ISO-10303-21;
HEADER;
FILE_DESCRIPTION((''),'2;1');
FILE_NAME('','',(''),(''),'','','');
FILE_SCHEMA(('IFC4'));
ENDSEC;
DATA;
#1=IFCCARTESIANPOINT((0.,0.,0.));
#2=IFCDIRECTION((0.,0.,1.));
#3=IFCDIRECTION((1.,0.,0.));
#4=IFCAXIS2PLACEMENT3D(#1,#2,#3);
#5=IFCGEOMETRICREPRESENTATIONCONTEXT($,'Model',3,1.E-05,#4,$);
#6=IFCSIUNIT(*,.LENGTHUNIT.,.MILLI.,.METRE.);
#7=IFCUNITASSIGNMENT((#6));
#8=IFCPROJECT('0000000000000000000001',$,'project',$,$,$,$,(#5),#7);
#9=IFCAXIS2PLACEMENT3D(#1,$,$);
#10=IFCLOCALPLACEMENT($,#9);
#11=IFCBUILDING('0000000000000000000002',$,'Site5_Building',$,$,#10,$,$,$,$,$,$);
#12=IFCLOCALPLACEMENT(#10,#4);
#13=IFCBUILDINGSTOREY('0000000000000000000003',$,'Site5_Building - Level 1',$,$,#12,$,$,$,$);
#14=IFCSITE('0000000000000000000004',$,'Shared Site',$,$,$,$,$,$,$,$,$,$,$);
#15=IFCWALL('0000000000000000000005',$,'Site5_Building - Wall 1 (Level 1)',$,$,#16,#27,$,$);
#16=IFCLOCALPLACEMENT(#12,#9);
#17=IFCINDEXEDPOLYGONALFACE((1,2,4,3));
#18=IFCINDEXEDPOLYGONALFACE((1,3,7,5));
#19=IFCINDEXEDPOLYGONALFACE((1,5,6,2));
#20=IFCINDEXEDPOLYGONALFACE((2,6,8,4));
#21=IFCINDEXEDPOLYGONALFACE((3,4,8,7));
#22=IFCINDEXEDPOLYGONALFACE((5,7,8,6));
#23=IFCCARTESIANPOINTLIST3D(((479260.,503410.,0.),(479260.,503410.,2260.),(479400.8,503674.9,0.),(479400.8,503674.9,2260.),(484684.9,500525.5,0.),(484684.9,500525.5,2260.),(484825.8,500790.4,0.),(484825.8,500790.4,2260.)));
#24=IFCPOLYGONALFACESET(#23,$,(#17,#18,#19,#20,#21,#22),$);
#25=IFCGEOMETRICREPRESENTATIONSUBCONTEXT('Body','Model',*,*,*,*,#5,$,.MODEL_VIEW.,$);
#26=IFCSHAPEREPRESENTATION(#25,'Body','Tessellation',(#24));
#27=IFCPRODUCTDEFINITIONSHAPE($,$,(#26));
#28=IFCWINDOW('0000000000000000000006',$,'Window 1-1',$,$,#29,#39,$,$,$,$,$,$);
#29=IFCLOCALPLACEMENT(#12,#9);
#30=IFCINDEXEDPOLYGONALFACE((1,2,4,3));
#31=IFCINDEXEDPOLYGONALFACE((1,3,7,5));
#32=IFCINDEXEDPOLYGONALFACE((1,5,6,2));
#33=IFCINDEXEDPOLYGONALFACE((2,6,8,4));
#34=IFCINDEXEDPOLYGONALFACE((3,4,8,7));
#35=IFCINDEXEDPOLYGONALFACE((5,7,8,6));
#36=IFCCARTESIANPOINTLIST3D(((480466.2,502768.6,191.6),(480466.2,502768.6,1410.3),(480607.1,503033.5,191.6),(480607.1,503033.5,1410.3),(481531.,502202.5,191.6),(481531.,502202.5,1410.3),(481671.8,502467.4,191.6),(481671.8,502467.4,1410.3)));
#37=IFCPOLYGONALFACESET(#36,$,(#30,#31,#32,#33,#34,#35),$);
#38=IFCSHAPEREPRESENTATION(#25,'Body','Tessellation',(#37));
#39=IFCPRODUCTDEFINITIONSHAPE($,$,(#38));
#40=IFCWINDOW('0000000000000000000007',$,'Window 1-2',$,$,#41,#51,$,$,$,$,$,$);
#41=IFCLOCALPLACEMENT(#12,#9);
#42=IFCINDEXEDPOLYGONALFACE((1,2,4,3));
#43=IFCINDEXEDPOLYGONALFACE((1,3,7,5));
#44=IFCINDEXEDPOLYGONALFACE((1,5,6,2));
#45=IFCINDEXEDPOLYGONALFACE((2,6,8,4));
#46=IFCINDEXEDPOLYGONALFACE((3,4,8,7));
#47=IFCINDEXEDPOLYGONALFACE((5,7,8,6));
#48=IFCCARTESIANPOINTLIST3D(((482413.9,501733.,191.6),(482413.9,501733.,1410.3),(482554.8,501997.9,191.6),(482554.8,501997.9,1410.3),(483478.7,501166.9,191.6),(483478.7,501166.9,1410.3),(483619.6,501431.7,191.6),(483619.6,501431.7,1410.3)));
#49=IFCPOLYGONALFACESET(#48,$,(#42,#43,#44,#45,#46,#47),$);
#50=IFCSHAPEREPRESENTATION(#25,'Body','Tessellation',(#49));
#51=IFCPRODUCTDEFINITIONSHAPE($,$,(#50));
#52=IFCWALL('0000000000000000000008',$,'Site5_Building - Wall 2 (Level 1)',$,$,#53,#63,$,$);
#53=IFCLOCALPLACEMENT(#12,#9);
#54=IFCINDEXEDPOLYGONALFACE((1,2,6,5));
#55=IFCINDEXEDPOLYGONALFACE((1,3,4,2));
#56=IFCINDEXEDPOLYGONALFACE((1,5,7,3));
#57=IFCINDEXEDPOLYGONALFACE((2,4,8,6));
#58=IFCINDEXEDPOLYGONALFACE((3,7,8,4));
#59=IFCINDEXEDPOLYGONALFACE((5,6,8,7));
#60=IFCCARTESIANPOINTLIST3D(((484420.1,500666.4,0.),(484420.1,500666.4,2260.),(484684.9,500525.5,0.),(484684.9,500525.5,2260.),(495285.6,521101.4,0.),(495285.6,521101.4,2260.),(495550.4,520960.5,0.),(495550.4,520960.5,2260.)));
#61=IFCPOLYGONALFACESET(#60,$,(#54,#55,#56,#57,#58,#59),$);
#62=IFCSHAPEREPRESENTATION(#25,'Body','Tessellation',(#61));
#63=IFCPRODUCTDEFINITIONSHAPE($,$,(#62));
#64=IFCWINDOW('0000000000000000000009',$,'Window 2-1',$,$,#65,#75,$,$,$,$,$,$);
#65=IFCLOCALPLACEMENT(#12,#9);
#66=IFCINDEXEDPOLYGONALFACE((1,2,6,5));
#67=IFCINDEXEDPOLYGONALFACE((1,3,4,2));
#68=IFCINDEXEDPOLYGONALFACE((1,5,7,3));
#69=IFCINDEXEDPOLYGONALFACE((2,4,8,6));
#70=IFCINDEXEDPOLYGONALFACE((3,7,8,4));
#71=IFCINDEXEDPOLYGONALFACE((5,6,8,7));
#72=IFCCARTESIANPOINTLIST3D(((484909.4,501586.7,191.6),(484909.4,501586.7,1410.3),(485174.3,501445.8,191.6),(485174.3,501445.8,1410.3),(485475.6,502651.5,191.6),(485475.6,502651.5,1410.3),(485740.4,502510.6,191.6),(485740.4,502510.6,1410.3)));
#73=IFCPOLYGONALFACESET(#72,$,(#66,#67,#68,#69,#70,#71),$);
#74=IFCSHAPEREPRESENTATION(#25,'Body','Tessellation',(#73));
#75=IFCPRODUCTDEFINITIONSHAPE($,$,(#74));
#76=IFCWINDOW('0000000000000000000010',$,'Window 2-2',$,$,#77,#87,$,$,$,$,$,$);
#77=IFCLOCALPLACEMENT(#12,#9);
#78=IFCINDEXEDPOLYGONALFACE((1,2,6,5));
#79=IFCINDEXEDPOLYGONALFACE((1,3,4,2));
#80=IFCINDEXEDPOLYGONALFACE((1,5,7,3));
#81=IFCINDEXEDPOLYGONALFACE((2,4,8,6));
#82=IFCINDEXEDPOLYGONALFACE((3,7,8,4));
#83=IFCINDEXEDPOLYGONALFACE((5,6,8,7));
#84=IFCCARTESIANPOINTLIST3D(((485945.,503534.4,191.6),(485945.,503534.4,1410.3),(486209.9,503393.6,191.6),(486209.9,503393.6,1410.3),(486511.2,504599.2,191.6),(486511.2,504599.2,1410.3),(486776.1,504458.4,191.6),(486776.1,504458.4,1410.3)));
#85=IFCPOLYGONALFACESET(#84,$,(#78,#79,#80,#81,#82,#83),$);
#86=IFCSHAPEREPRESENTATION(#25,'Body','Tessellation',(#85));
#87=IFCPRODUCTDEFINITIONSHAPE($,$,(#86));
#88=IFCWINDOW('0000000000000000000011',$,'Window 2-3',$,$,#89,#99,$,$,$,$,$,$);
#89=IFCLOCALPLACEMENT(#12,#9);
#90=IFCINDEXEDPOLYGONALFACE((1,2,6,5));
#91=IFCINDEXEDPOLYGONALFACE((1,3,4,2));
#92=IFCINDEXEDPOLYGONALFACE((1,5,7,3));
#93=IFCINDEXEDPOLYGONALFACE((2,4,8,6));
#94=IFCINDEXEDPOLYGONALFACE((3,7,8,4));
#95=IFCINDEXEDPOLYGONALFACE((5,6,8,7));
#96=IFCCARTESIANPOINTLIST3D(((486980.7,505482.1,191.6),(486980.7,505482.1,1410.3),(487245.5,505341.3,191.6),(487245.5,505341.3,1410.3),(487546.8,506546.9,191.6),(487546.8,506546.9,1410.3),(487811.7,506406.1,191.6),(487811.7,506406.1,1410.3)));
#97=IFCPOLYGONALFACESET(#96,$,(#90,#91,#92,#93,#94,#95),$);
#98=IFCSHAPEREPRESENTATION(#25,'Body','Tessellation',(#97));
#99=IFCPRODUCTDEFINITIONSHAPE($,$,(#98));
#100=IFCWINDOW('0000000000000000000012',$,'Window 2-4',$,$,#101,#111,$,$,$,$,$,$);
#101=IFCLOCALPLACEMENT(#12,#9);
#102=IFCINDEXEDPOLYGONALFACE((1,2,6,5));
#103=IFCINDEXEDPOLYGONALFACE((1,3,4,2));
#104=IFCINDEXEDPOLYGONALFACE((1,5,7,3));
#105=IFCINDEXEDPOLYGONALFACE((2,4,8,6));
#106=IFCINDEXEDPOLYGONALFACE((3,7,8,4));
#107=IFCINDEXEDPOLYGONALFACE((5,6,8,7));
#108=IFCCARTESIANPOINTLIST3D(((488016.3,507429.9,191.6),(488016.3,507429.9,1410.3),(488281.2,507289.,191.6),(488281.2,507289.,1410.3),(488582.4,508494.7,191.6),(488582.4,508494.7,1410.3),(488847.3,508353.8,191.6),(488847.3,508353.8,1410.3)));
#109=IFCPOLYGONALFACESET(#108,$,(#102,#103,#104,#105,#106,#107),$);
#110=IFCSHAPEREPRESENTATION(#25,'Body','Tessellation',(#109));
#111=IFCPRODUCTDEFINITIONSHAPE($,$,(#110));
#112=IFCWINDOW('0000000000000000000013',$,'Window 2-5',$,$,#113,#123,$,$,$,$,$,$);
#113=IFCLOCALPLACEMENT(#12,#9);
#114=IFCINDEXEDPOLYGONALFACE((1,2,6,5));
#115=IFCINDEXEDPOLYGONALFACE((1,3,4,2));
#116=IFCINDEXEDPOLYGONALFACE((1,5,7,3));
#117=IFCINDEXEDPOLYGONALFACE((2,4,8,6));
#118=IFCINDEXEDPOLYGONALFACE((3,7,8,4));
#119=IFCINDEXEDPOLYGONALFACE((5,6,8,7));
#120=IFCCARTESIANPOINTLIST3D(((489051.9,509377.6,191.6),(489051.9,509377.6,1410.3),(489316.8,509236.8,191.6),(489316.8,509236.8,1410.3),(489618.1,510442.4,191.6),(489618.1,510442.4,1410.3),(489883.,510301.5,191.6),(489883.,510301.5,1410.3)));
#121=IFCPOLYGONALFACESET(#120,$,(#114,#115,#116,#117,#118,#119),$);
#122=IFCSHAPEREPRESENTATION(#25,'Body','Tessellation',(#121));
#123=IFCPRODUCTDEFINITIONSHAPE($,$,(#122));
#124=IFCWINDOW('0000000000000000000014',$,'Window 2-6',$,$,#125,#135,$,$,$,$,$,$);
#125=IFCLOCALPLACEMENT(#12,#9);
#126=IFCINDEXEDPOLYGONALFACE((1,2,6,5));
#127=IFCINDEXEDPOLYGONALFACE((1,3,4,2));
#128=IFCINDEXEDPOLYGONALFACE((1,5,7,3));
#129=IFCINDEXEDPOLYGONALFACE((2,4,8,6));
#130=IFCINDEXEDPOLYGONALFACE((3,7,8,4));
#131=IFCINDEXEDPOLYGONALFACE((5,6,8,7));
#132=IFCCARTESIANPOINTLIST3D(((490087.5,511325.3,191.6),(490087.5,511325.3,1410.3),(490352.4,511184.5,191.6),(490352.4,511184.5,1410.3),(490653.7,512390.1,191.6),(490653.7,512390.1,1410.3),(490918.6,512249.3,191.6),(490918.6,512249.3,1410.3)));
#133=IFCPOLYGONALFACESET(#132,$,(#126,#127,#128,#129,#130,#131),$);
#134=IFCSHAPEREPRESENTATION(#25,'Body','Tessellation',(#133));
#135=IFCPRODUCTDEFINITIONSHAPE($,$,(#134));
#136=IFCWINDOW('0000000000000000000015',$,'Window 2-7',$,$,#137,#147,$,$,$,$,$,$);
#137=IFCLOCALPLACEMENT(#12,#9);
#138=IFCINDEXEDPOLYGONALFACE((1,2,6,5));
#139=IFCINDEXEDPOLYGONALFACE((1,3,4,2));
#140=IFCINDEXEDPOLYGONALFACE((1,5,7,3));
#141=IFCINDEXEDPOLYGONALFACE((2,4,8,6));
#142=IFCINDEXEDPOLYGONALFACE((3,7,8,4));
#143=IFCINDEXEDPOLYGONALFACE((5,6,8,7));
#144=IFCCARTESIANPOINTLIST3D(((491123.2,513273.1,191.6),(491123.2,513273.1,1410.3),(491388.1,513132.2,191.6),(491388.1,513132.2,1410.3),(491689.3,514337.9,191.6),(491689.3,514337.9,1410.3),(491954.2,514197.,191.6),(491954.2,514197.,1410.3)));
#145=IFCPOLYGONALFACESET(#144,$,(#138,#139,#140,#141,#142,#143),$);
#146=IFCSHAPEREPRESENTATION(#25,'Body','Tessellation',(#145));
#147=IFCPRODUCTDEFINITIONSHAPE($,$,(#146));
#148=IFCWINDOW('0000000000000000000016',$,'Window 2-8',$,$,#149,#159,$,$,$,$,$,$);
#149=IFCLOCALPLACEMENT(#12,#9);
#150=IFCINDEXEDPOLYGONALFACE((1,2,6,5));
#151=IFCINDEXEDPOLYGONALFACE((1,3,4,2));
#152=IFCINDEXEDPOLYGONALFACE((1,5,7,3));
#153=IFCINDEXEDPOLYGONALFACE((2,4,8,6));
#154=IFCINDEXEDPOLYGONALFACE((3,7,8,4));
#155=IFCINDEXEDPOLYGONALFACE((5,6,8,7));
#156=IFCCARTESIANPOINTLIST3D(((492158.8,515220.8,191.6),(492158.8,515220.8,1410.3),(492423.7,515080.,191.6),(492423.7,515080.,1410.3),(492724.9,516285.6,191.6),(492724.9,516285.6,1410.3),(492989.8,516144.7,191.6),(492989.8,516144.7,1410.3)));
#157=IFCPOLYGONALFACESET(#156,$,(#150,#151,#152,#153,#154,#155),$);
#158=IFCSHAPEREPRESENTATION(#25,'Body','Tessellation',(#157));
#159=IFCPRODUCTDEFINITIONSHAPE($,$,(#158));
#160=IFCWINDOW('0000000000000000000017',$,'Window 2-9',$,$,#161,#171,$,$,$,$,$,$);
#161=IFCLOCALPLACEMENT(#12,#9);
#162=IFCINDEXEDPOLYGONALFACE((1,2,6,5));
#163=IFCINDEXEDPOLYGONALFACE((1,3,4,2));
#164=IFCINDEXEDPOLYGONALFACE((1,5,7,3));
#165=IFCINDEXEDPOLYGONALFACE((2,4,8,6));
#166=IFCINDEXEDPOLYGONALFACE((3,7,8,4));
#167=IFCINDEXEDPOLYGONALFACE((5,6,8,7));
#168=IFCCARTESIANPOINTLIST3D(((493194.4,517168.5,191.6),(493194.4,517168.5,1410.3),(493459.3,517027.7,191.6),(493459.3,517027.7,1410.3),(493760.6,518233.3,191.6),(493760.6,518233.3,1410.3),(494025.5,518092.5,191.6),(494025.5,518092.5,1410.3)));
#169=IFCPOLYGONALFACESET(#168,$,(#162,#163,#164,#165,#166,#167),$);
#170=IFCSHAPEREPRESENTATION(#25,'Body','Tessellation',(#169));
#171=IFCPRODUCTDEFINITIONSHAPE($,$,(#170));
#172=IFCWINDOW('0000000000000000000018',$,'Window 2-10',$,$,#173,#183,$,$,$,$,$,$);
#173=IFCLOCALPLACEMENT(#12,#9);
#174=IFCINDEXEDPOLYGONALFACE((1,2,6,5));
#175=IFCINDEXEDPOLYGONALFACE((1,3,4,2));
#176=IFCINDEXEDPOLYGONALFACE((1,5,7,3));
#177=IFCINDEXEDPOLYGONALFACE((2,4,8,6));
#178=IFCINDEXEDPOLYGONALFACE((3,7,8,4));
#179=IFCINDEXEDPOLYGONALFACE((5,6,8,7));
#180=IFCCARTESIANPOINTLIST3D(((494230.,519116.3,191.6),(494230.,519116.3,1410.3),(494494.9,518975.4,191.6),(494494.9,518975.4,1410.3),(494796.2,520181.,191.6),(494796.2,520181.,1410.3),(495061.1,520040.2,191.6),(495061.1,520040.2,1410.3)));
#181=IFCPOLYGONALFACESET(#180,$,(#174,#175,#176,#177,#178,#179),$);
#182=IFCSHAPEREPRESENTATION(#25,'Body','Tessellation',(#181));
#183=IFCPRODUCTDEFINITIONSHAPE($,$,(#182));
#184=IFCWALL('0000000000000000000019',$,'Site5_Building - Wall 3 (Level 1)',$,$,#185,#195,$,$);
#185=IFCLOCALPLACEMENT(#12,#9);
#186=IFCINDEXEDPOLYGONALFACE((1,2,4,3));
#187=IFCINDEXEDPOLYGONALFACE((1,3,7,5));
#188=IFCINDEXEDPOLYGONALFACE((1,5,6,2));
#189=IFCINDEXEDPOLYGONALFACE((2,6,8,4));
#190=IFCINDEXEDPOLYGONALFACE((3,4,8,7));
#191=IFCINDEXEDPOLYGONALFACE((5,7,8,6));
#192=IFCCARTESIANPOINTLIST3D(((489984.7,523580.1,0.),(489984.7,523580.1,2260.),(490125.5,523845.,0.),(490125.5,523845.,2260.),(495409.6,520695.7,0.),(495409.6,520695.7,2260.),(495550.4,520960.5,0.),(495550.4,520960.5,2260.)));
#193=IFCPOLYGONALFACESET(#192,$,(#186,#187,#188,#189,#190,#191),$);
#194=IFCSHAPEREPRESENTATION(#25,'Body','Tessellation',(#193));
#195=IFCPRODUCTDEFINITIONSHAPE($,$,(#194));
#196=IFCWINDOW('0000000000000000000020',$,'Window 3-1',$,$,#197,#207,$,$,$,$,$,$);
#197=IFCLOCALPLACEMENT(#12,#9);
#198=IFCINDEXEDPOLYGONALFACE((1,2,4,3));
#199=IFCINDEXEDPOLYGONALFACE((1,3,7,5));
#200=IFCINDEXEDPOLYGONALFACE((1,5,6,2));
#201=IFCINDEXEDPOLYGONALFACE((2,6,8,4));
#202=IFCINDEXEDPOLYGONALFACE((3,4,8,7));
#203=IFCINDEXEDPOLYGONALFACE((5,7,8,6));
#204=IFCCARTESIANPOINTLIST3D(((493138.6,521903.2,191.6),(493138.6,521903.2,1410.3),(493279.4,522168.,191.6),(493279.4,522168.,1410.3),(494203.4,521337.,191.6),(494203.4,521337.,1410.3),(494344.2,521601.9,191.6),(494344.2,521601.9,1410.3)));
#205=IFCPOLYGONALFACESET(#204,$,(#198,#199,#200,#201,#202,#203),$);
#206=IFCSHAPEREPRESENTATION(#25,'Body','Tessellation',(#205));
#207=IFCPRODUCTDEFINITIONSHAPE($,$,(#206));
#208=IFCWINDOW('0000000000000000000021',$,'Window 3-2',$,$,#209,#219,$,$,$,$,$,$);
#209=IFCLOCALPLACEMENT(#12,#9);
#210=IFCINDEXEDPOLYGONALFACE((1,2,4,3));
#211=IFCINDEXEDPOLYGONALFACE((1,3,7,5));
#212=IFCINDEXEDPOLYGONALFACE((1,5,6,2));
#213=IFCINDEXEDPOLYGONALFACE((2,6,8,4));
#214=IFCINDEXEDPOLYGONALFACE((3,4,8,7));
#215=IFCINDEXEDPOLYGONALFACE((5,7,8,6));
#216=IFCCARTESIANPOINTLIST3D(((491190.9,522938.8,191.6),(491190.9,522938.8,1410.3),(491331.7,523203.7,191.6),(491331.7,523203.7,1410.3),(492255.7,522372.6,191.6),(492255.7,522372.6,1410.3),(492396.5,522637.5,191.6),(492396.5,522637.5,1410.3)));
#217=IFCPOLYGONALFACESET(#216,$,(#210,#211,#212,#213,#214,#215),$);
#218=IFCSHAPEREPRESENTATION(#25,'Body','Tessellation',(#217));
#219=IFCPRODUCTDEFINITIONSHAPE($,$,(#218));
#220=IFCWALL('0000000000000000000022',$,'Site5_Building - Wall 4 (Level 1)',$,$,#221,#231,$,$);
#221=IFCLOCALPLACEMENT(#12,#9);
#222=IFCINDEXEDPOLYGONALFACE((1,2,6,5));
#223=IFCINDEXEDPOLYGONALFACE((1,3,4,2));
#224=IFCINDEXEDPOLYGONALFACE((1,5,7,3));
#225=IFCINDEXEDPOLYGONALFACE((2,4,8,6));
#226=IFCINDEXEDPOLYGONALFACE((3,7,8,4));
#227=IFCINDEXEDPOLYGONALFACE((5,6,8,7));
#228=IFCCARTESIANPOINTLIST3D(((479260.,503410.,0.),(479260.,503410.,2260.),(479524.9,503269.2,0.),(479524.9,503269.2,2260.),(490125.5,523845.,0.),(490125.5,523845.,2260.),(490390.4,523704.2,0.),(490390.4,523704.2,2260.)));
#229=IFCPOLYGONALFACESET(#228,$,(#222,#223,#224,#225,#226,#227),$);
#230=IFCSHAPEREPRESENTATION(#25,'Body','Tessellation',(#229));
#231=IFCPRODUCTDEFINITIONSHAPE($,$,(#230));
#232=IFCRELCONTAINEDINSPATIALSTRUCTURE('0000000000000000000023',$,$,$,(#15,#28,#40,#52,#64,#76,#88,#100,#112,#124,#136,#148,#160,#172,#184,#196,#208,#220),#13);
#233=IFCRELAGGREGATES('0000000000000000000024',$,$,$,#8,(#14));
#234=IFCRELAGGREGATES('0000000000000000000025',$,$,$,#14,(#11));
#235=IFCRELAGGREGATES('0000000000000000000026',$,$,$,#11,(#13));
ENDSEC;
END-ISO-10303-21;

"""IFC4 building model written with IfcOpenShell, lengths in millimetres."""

from ifc_helpers import new_model, si_unit, frame, origin, origin_with_axes, place, context, subcontext, project, spatial, indexed_curve, outline, extrude, element, save


model = new_model("IFC4")

# Units and contexts
model_context = context("Model", 3, precision=1e-05, world=origin_with_axes())
body_context = subcontext(model_context, "Body", "Model", "MODEL_VIEW")
ifc_project = project(units=[si_unit("LENGTHUNIT", "METRE", prefix="MILLI")], contexts=[model_context])

# Site, building, storey
site = spatial("IfcSite", under=ifc_project, Name="Shared Site")
building_placement = place(None, origin())
building = spatial("IfcBuilding", under=site, at=building_placement, Name="Site5_Building")
storey_placement = place(building_placement, origin_with_axes())
storey = spatial("IfcBuildingStorey", under=building, at=storey_placement, Name="Site5_Building - Level 1")

# Wall
wall_1_placement = place(storey_placement, frame((479260.0, 503410.0, 0.0), z_axis=(0.0, 0.0, 1.0), x_axis=(0.882948, -0.469472, 0.0)))
element("IfcWall", 1, at=wall_1_placement, inside=storey, Name="Site5_Building - Wall 1 (Level 1)", context=body_context, shape_type="SweptSolid", body=[
    extrude(outline(indexed_curve([(0.0, 0.0), (0.0, 300.0), (6144.1, 300.0), (6144.1, 0.0), (0.0, 0.0)], self_intersect=False)), origin_with_axes(), (0.0, 0.0, 1.0), 2260.0),
])

# Windows
for number, where, z_axis, x_axis, name in (
    (2, (480466.2, 502768.6, 191.6), (0.0, 0.0, 1.0), (0.882948, -0.469472, 0.0), "Window 1-1"),
    (3, (482413.9, 501733.0, 191.6), (0.0, 0.0, 1.0), (0.882948, -0.469472, 0.0), "Window 1-2"),
):
    element("IfcWindow", number, at=place(storey_placement, frame(where, z_axis=z_axis, x_axis=x_axis)), inside=storey, Name=name, context=body_context, shape_type="SweptSolid", body=[
        extrude(outline(indexed_curve([(0.0, 0.0), (0.0, 300.0), (1205.9, 300.0), (1205.9, 0.0), (0.0, 0.0)], self_intersect=False)), origin_with_axes(), (0.0, 0.0, 1.0), 1218.8),
    ])

# Wall
wall_2_placement = place(storey_placement, frame((484684.9, 500525.5, 0.0), z_axis=(0.0, 0.0, 1.0), x_axis=(0.469472, 0.882948, 0.0)))
element("IfcWall", 4, at=wall_2_placement, inside=storey, Name="Site5_Building - Wall 2 (Level 1)", context=body_context, shape_type="SweptSolid", body=[
    extrude(outline(indexed_curve([(0.0, 0.0), (0.0, 300.0), (23144.1, 300.0), (23144.1, 0.0), (0.0, 0.0)], self_intersect=False)), origin_with_axes(), (0.0, 0.0, 1.0), 2260.0),
])

# Windows
for number, where, z_axis, x_axis, name in (
    (5, (485174.3, 501445.8, 191.6), (0.0, 0.0, 1.0), (0.469472, 0.882948, 0.0), "Window 2-1"),
    (6, (486209.9, 503393.6, 191.6), (0.0, 0.0, 1.0), (0.469472, 0.882948, 0.0), "Window 2-2"),
    (7, (487245.5, 505341.3, 191.6), (0.0, 0.0, 1.0), (0.469472, 0.882948, 0.0), "Window 2-3"),
    (8, (488281.2, 507289.0, 191.6), (0.0, 0.0, 1.0), (0.469472, 0.882948, 0.0), "Window 2-4"),
    (9, (489316.8, 509236.8, 191.6), (0.0, 0.0, 1.0), (0.469472, 0.882948, 0.0), "Window 2-5"),
    (10, (490352.4, 511184.5, 191.6), (0.0, 0.0, 1.0), (0.469472, 0.882948, 0.0), "Window 2-6"),
    (11, (491388.1, 513132.2, 191.6), (0.0, 0.0, 1.0), (0.469472, 0.882948, 0.0), "Window 2-7"),
    (12, (492423.7, 515080.0, 191.6), (0.0, 0.0, 1.0), (0.469472, 0.882948, 0.0), "Window 2-8"),
    (13, (493459.3, 517027.7, 191.6), (0.0, 0.0, 1.0), (0.469472, 0.882948, 0.0), "Window 2-9"),
    (14, (494494.9, 518975.4, 191.6), (0.0, 0.0, 1.0), (0.469472, 0.882948, 0.0), "Window 2-10"),
):
    element("IfcWindow", number, at=place(storey_placement, frame(where, z_axis=z_axis, x_axis=x_axis)), inside=storey, Name=name, context=body_context, shape_type="SweptSolid", body=[
        extrude(outline(indexed_curve([(0.0, 0.0), (0.0, 300.0), (1205.9, 300.0), (1205.9, 0.0), (0.0, 0.0)], self_intersect=False)), origin_with_axes(), (0.0, 0.0, 1.0), 1218.8),
    ])

# Wall
wall_3_placement = place(storey_placement, frame((495550.4, 520960.5, 0.0), z_axis=(0.0, 0.0, 1.0), x_axis=(-0.882948, 0.469472, 0.0)))
element("IfcWall", 15, at=wall_3_placement, inside=storey, Name="Site5_Building - Wall 3 (Level 1)", context=body_context, shape_type="SweptSolid", body=[
    extrude(outline(indexed_curve([(0.0, 0.0), (0.0, 300.0), (6144.1, 300.0), (6144.1, 0.0), (0.0, 0.0)], self_intersect=False)), origin_with_axes(), (0.0, 0.0, 1.0), 2260.0),
])

# Windows
for number, where, z_axis, x_axis, name in (
    (16, (494344.2, 521601.9, 191.6), (0.0, 0.0, 1.0), (-0.882948, 0.469472, 0.0), "Window 3-1"),
    (17, (492396.5, 522637.5, 191.6), (0.0, 0.0, 1.0), (-0.882948, 0.469472, 0.0), "Window 3-2"),
):
    element("IfcWindow", number, at=place(storey_placement, frame(where, z_axis=z_axis, x_axis=x_axis)), inside=storey, Name=name, context=body_context, shape_type="SweptSolid", body=[
        extrude(outline(indexed_curve([(0.0, 0.0), (0.0, 300.0), (1205.9, 300.0), (1205.9, 0.0), (0.0, 0.0)], self_intersect=False)), origin_with_axes(), (0.0, 0.0, 1.0), 1218.8),
    ])

# Wall
wall_4_placement = place(storey_placement, frame((490125.5, 523845.0, 0.0), z_axis=(0.0, 0.0, 1.0), x_axis=(-0.469472, -0.882948, 0.0)))
element("IfcWall", 18, at=wall_4_placement, inside=storey, Name="Site5_Building - Wall 4 (Level 1)", context=body_context, shape_type="SweptSolid", body=[
    extrude(outline(indexed_curve([(0.0, 0.0), (0.0, 300.0), (23144.1, 300.0), (23144.1, 0.0), (0.0, 0.0)], self_intersect=False)), origin_with_axes(), (0.0, 0.0, 1.0), 2260.0),
])

save(model, "model.ifc")
